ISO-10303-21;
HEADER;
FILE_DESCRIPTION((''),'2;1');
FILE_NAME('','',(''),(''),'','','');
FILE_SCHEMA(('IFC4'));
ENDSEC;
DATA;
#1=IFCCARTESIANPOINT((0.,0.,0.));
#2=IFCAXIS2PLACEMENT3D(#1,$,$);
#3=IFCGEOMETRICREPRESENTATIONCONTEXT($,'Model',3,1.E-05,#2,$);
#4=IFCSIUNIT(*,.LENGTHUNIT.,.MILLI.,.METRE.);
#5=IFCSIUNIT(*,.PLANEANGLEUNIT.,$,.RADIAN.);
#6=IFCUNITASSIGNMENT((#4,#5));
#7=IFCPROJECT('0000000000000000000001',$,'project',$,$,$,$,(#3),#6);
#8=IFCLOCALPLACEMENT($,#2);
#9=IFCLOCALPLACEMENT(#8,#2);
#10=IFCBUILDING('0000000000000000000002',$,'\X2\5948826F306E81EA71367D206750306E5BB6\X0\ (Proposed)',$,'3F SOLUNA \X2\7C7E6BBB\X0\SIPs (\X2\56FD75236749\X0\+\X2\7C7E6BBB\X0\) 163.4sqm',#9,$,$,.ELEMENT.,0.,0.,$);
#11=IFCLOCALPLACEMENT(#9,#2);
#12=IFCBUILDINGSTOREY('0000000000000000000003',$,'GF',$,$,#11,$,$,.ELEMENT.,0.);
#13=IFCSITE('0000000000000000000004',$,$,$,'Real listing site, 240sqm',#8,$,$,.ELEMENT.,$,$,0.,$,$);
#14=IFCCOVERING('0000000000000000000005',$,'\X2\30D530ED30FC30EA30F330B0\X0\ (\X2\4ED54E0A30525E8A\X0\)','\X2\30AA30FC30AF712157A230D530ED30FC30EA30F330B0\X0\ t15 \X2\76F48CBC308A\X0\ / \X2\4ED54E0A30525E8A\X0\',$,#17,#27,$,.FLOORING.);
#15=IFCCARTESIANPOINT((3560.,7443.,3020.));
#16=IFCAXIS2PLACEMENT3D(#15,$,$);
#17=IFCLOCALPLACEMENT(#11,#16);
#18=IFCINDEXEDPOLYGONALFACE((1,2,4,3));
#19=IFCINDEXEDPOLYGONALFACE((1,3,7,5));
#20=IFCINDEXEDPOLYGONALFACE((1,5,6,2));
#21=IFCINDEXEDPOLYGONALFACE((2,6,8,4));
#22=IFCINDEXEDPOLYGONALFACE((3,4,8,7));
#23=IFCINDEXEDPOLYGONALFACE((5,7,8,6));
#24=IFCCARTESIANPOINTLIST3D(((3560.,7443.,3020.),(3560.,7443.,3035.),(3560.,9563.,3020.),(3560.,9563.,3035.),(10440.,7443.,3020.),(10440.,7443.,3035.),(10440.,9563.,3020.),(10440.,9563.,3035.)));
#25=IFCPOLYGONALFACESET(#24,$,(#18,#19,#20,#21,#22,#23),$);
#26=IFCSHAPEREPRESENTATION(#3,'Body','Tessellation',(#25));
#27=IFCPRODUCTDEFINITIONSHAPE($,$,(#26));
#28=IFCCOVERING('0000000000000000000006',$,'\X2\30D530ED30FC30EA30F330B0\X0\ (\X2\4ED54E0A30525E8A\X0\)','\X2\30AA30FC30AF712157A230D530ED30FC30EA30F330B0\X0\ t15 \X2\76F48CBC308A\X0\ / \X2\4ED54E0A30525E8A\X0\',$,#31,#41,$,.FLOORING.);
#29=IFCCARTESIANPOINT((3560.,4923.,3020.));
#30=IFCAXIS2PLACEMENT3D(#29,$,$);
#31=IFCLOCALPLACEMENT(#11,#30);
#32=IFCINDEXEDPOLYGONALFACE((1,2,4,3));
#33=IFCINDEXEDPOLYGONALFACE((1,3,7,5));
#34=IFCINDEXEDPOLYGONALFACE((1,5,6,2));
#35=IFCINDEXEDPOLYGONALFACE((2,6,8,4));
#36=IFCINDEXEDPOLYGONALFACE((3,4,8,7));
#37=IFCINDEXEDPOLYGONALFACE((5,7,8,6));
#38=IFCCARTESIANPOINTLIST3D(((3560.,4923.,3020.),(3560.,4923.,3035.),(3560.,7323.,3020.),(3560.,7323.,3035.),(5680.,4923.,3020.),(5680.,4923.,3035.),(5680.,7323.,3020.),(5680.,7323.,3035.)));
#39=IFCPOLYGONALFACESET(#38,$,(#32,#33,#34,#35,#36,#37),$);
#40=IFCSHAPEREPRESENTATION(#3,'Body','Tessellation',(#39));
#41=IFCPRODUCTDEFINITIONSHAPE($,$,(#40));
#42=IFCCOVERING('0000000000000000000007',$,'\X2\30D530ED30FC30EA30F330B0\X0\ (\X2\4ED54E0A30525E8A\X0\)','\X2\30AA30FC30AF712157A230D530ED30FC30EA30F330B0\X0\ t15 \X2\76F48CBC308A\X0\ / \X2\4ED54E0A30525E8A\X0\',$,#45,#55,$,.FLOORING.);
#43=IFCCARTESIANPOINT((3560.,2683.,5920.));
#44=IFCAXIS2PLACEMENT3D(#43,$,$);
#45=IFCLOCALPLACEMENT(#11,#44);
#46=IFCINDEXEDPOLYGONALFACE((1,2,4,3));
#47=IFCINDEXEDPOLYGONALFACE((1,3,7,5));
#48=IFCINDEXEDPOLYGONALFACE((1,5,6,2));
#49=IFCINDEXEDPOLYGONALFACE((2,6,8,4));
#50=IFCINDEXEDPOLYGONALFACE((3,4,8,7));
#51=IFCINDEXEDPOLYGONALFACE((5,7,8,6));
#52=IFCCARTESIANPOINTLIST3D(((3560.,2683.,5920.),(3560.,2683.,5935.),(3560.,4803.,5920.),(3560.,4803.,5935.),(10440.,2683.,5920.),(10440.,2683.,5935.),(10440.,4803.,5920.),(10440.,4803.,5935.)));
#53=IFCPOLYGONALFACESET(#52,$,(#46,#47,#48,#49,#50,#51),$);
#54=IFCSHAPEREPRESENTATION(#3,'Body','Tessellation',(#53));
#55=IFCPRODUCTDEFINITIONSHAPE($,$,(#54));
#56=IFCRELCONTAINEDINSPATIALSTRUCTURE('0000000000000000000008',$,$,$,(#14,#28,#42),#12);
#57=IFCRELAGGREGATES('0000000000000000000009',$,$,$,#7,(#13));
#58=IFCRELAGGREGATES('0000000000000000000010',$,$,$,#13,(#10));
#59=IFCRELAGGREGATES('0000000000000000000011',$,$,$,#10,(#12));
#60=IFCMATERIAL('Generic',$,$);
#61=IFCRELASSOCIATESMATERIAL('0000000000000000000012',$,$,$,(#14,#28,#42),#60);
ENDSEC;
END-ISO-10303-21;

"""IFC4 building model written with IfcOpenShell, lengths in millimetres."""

from ifc_helpers import new_model, si_unit, frame, frame_2d, origin, place, context, project, spatial, rectangle, extrude, material, element, save


model = new_model("IFC4")

# Units and contexts
model_context = context("Model", 3, precision=1e-05, world=origin())
ifc_project = project(units=[si_unit("LENGTHUNIT", "METRE", prefix="MILLI"), si_unit("PLANEANGLEUNIT", "RADIAN")], contexts=[model_context])

# Site, building, storey
site_placement = place(None, origin())
site = spatial("IfcSite", under=ifc_project, at=site_placement, ObjectType="Real listing site, 240sqm", CompositionType="ELEMENT", RefElevation=0.0)
building_placement = place(site_placement, origin())
building = spatial("IfcBuilding", under=site, at=building_placement, Name="奈良の自然素材の家 (Proposed)", ObjectType="3F SOLUNA 籾殻SIPs (国産杉+籾殻) 163.4sqm", CompositionType="ELEMENT", ElevationOfRefHeight=0.0, ElevationOfTerrain=0.0)
storey_placement = place(building_placement, origin())
storey = spatial("IfcBuildingStorey", under=building, at=storey_placement, Name="GF", CompositionType="ELEMENT", Elevation=0.0)

# Shared definitions
ifc_material_1 = material(Name="Generic")

# Coverings
covering_1_placement = place(storey_placement, frame((3560.0, 7443.0, 3020.0)))
element("IfcCovering", 1, at=covering_1_placement, inside=storey, material=ifc_material_1, Name="フローリング (仕上げ床)", Description="オーク無垢フローリング t15 直貼り / 仕上げ床", PredefinedType="FLOORING", context=model_context, shape_type="SweptSolid", body=[
    extrude(rectangle(XDim=6880.0, YDim=2120.0, at=frame_2d((3440.0, 1060.0))), frame((3560.0, 7443.0, 3020.0)), (0.0, 0.0, 1.0), 15.0),
])
covering_2_placement = place(storey_placement, frame((3560.0, 4923.0, 3020.0)))
element("IfcCovering", 2, at=covering_2_placement, inside=storey, material=ifc_material_1, Name="フローリング (仕上げ床)", Description="オーク無垢フローリング t15 直貼り / 仕上げ床", PredefinedType="FLOORING", context=model_context, shape_type="SweptSolid", body=[
    extrude(rectangle(XDim=2120.0, YDim=2400.0, at=frame_2d((1060.0, 1200.0))), frame((3560.0, 4923.0, 3020.0)), (0.0, 0.0, 1.0), 15.0),
])
covering_3_placement = place(storey_placement, frame((3560.0, 2683.0, 5920.0)))
element("IfcCovering", 3, at=covering_3_placement, inside=storey, material=ifc_material_1, Name="フローリング (仕上げ床)", Description="オーク無垢フローリング t15 直貼り / 仕上げ床", PredefinedType="FLOORING", context=model_context, shape_type="SweptSolid", body=[
    extrude(rectangle(XDim=6880.0, YDim=2120.0, at=frame_2d((3440.0, 1060.0))), frame((3560.0, 2683.0, 5920.0)), (0.0, 0.0, 1.0), 15.0),
])

save(model, "model.ifc")
